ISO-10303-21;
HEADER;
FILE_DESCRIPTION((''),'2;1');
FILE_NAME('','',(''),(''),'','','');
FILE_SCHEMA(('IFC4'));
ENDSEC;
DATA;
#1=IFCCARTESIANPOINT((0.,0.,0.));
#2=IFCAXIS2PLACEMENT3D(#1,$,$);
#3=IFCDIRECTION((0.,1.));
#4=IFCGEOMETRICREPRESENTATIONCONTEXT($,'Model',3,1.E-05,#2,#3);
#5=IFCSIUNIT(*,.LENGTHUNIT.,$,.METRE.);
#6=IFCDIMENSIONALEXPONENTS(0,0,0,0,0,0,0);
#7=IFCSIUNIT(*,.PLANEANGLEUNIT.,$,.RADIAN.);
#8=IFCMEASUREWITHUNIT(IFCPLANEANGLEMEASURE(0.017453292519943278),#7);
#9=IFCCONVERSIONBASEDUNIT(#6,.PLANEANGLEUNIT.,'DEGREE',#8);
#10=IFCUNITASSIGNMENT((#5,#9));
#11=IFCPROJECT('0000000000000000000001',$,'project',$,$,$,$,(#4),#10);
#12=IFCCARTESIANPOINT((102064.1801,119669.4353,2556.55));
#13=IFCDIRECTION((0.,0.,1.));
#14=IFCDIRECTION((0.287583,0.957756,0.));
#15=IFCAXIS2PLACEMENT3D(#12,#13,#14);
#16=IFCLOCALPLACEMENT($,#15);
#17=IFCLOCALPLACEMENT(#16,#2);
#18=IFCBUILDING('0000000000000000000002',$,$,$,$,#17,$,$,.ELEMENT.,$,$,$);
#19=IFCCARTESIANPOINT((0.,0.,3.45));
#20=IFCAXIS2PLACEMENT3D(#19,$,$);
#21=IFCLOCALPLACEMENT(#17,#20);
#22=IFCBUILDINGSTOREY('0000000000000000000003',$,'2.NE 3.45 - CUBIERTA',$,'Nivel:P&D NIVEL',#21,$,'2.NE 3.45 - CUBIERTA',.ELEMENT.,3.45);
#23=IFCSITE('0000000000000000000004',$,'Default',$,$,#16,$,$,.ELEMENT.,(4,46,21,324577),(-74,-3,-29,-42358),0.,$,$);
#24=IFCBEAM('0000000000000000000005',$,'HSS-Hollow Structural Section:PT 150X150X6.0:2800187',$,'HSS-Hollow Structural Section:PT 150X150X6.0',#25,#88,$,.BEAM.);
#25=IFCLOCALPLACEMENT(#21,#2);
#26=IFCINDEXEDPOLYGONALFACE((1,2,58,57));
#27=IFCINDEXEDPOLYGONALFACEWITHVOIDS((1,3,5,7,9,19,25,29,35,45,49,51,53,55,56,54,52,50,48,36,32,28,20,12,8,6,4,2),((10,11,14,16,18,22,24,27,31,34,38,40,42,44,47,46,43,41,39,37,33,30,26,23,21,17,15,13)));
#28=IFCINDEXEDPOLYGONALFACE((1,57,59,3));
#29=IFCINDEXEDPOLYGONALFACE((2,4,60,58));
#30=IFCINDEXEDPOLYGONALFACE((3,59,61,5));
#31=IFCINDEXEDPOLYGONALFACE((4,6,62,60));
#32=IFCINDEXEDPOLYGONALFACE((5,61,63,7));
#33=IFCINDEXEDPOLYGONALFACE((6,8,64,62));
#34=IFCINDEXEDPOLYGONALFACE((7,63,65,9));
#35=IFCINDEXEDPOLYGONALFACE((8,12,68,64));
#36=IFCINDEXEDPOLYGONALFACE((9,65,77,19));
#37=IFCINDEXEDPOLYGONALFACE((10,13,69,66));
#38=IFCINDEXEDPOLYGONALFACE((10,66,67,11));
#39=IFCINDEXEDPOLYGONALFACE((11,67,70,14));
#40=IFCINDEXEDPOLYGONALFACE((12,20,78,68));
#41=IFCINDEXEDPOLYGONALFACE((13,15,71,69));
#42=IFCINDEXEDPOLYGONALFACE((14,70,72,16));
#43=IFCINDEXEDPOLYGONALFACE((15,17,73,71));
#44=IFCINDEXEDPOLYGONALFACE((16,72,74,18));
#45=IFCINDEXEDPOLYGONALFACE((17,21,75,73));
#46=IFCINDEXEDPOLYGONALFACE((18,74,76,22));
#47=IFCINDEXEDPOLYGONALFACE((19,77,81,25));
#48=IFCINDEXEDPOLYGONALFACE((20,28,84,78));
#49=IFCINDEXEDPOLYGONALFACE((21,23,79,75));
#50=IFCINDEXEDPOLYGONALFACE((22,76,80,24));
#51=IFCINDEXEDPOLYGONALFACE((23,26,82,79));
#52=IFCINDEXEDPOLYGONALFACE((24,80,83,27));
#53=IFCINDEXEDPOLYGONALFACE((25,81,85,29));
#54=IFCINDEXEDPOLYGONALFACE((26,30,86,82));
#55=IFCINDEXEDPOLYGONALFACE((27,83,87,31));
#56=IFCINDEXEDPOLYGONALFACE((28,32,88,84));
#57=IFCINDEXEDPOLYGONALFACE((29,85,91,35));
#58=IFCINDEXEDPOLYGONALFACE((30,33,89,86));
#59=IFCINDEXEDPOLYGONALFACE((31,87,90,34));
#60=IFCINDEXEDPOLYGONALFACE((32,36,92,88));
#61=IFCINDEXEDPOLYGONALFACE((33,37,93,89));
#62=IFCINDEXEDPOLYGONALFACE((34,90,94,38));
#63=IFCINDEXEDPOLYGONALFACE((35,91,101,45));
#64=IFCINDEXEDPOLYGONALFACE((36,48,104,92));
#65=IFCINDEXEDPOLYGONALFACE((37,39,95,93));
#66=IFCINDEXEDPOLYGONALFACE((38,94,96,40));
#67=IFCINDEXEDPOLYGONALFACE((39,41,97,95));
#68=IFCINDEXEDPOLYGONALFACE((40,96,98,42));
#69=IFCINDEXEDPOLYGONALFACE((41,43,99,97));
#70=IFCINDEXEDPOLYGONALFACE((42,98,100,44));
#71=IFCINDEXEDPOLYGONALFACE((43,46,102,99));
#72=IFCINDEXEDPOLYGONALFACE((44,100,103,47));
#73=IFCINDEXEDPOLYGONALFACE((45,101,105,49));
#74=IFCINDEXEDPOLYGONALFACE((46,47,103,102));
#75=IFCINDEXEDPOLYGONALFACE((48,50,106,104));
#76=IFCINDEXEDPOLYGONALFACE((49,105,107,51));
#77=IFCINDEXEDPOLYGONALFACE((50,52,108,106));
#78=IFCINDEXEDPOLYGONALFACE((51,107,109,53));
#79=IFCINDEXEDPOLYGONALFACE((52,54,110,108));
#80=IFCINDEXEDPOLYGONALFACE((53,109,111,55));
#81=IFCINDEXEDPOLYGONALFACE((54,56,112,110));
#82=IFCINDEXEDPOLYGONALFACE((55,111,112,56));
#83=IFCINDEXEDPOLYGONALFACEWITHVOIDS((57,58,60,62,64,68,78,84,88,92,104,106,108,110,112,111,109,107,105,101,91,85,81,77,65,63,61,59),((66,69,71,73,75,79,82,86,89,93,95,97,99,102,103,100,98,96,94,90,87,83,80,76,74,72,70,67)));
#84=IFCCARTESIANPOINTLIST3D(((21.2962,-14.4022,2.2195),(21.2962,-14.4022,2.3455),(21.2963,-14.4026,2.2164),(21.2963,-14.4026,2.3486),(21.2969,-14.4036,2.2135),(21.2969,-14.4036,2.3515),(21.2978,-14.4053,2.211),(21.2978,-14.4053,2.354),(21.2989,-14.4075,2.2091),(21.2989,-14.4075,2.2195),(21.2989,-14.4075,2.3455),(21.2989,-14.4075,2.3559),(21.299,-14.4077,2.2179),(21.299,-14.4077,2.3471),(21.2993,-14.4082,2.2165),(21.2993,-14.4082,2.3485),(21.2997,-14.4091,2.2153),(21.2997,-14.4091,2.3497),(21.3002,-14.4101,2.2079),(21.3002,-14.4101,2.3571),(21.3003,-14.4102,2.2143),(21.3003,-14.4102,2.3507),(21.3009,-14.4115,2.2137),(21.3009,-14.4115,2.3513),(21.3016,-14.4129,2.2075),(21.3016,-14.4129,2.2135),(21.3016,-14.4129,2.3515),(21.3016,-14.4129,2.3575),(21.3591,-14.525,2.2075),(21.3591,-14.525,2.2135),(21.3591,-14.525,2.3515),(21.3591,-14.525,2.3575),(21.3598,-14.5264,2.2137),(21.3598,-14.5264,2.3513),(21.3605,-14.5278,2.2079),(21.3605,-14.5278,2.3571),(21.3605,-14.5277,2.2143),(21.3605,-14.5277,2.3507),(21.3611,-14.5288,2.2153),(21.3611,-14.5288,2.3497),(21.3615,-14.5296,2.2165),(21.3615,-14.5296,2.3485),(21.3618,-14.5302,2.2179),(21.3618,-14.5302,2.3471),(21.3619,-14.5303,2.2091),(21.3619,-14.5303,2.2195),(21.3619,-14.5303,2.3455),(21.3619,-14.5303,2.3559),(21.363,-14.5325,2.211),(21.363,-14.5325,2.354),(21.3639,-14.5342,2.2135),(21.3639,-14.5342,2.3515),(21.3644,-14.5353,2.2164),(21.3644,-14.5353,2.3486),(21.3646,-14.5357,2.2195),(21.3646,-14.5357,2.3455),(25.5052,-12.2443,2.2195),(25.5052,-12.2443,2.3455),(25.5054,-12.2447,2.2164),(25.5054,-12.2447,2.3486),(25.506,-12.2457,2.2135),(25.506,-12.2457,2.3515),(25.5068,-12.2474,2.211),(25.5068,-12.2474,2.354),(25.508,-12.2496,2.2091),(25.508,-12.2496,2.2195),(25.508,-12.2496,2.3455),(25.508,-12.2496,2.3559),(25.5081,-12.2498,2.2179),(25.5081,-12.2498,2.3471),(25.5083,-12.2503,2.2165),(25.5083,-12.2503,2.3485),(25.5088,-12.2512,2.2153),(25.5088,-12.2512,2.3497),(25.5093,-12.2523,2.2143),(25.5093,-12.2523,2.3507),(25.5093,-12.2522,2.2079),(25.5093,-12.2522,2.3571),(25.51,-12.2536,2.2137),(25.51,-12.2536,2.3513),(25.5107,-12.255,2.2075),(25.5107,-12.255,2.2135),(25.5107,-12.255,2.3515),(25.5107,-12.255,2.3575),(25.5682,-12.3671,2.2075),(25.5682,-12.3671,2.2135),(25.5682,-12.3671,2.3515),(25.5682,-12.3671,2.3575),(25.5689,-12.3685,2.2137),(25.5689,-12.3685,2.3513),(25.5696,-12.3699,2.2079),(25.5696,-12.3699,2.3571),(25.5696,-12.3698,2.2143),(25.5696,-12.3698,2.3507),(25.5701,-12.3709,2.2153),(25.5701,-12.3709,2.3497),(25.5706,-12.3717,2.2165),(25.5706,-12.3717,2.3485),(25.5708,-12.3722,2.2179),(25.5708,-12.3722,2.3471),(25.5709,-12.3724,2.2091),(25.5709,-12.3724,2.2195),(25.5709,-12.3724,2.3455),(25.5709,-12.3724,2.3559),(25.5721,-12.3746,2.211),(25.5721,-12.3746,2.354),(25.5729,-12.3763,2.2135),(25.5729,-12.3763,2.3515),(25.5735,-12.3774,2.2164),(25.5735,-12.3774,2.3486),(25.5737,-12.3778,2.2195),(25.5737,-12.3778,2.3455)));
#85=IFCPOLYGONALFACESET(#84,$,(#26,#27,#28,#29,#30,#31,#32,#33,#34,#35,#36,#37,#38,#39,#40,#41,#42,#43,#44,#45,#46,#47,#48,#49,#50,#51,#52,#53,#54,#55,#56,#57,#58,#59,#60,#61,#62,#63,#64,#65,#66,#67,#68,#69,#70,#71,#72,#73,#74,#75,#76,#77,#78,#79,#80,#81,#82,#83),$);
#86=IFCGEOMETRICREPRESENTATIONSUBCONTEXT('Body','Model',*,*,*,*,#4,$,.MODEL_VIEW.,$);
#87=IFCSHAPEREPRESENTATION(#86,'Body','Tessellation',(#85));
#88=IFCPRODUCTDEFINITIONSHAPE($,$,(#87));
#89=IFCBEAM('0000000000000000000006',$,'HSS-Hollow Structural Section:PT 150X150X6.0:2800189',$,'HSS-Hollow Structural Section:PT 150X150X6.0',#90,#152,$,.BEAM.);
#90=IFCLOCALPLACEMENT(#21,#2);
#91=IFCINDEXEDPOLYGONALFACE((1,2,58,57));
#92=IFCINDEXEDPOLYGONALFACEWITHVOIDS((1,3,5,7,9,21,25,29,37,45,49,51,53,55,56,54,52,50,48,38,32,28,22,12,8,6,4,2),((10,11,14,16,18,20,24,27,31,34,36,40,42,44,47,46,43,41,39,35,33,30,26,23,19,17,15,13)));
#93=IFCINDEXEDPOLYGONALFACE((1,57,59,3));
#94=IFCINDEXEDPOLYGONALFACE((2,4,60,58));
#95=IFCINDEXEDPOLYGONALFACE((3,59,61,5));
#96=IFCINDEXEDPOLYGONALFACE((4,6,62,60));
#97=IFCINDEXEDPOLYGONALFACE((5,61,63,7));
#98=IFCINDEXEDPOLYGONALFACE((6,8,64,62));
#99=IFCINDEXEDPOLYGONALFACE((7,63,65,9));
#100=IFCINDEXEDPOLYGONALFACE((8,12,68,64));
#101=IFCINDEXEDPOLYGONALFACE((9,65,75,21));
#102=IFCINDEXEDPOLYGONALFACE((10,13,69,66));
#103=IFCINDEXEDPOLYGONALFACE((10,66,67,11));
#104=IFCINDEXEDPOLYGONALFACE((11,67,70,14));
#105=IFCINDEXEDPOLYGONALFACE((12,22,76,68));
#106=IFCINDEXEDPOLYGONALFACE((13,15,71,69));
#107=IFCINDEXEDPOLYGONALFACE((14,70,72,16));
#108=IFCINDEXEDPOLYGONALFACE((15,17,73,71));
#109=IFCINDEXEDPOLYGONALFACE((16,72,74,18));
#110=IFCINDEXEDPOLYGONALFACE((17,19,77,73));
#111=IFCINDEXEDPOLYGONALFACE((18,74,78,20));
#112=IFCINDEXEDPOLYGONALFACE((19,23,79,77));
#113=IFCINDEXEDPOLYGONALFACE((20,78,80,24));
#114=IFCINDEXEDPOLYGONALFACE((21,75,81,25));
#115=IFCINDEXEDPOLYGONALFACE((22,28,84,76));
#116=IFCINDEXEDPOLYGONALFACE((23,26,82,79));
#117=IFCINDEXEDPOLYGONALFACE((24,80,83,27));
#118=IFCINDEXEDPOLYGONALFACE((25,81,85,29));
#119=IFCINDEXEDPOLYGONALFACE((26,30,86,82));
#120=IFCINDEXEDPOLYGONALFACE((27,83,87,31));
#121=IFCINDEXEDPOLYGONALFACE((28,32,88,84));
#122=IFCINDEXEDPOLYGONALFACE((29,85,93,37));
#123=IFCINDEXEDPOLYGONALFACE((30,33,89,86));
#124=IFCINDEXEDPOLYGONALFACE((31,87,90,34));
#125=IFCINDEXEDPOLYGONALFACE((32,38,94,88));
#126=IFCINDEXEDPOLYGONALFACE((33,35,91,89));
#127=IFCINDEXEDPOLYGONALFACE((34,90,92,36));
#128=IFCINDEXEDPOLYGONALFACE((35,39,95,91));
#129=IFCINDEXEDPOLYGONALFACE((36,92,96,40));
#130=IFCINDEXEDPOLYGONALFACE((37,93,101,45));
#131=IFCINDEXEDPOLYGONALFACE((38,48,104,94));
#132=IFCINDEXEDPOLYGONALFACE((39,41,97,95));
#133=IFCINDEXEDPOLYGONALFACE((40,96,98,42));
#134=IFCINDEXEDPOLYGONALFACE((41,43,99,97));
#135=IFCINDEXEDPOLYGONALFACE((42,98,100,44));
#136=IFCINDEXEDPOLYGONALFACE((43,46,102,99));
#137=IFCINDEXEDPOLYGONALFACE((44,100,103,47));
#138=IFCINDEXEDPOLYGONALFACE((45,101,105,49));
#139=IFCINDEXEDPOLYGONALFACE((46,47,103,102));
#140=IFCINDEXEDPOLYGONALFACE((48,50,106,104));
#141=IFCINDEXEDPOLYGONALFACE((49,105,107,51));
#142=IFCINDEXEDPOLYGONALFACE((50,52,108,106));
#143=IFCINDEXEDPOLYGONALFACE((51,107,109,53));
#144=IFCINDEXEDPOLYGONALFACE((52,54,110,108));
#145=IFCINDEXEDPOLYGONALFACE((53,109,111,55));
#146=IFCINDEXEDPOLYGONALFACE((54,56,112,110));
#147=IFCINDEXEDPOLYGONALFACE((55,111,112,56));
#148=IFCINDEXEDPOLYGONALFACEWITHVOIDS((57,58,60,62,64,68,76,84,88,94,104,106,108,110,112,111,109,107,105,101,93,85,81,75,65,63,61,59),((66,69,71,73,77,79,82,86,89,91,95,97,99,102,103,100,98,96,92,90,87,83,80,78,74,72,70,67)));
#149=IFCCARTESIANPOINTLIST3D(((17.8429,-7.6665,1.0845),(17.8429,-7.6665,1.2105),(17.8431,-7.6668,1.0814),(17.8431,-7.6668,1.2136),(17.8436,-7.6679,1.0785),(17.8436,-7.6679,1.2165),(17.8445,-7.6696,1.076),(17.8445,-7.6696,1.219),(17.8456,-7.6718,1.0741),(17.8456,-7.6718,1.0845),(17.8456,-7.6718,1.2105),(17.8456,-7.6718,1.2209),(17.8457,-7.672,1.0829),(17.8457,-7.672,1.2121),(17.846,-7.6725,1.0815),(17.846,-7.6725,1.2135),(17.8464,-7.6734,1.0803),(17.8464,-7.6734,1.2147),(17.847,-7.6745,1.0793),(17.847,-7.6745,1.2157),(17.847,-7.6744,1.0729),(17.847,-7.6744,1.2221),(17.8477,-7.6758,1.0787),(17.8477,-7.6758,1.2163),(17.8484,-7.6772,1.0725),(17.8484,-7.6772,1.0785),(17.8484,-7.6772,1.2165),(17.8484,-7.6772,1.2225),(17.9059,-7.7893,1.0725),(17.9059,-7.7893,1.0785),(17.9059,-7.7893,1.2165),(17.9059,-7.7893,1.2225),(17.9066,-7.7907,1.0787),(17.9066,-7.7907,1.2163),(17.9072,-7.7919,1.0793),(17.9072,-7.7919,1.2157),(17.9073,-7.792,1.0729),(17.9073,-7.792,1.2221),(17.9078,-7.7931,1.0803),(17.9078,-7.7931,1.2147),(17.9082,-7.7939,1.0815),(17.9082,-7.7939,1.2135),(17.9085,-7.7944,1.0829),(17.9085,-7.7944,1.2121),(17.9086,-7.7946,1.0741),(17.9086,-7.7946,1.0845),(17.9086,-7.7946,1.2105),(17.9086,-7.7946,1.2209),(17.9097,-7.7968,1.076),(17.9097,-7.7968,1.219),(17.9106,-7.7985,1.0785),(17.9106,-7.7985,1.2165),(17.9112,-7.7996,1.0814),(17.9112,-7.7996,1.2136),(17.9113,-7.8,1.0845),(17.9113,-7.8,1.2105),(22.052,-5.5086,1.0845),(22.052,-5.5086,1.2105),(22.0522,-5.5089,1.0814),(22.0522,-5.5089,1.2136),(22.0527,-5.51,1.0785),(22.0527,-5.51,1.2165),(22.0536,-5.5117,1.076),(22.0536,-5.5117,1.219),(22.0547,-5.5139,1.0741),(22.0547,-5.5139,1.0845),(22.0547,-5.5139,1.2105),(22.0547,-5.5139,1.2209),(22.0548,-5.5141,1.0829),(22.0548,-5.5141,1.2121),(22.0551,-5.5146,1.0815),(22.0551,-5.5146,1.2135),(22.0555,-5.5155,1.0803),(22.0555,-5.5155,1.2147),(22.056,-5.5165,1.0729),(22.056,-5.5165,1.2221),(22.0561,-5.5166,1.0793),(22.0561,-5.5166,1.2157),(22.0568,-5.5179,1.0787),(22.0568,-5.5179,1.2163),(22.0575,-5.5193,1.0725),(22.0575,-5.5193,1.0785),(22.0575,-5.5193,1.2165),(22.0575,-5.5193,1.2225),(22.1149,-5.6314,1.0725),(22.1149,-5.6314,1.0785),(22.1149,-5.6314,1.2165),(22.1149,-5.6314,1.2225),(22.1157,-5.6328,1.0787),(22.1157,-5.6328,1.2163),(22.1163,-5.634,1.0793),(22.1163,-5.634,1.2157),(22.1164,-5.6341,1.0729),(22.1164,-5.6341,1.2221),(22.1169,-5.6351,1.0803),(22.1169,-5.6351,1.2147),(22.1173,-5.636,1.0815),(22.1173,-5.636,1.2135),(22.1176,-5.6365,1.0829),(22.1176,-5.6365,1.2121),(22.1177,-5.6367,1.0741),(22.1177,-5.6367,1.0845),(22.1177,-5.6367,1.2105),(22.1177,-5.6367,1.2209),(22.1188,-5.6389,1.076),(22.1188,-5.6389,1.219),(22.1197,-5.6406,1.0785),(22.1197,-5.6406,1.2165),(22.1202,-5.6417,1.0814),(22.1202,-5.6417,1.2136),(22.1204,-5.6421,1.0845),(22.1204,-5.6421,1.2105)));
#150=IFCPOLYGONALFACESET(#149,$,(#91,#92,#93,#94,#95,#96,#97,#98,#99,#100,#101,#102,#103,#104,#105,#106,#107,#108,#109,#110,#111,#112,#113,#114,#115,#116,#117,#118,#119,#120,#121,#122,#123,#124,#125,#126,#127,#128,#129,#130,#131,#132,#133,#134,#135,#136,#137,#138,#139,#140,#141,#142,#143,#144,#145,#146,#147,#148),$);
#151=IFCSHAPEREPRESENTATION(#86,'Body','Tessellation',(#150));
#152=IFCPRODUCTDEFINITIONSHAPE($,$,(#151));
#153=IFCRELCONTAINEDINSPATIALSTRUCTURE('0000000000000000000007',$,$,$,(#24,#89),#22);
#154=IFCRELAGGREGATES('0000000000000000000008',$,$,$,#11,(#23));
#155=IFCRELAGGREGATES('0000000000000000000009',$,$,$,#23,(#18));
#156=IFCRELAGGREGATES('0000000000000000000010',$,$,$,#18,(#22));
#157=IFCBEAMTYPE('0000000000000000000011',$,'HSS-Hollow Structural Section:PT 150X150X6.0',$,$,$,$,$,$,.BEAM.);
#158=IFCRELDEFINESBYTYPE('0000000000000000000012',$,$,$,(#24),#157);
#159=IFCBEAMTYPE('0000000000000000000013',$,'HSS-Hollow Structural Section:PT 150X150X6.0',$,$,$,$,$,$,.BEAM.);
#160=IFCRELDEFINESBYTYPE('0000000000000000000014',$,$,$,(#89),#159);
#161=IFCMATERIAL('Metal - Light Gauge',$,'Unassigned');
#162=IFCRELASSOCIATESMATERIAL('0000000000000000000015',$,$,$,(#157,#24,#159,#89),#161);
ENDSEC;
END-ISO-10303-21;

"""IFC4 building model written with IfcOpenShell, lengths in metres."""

from ifc_helpers import new_model, entity, si_unit, converted_unit, direction, frame, origin, place, context, subcontext, project, spatial, line, arc, indexed_curve, outline, extrude, source, transform, mapped, material, type_object, type_shapes, element, save


model = new_model("IFC4")

# Units and contexts
model_context = context("Model", 3, precision=1e-05, world=origin(), true_north=direction((0.0, 1.0)))
body_context = subcontext(model_context, "Body", "Model", "MODEL_VIEW")
ifc_project = project(units=[si_unit("LENGTHUNIT", "METRE"), converted_unit("PLANEANGLEUNIT", "DEGREE", entity("IfcPlaneAngleMeasure", 0.017453292519943278), si_unit("PLANEANGLEUNIT", "RADIAN"), dimensions=[0, 0, 0, 0, 0, 0, 0])], contexts=[model_context])

# Site, building, storey
site_placement = place(None, frame((102064.1801, 119669.4353, 2556.55), z_axis=(0.0, 0.0, 1.0), x_axis=(0.287583, 0.957756, 0.0)))
site = spatial("IfcSite", under=ifc_project, at=site_placement, Name="Default", CompositionType="ELEMENT", RefLatitude=(4, 46, 21, 324577), RefLongitude=(-74, -3, -29, -42358), RefElevation=0.0)
building_placement = place(site_placement, origin())
building = spatial("IfcBuilding", under=site, at=building_placement, CompositionType="ELEMENT")
storey_placement = place(building_placement, frame((0.0, 0.0, 3.45)))
storey = spatial("IfcBuildingStorey", under=building, at=storey_placement, Name="2.NE 3.45 - CUBIERTA", ObjectType="Nivel:P&D NIVEL", LongName="2.NE 3.45 - CUBIERTA", CompositionType="ELEMENT", Elevation=3.45)

# Beams
ifc_material_1 = material(Name="Metal - Light Gauge", Category="Unassigned")
beam_type_1 = type_object("IfcBeamType", Name="HSS-Hollow Structural Section:PT 150X150X6.0", PredefinedType="BEAM", material=ifc_material_1)
shared_shape_1 = source(origin(), body_context, "Body", "SweptSolid", [
    extrude(outline(indexed_curve([(-0.063, -0.075), (0.063, -0.075), (0.0715, -0.0715), (0.075, -0.063), (0.075, 0.063), (0.0715, 0.0715), (0.063, 0.075), (-0.063, 0.075), (-0.0715, 0.0715), (-0.075, 0.063), (-0.075, -0.063), (-0.0715, -0.0715)], segments=[line(1, 2), arc(2, 3, 4), line(4, 5), arc(5, 6, 7), line(7, 8), arc(8, 9, 10), line(10, 11), arc(11, 12, 1)], self_intersect=False), holes=[indexed_curve([(-0.069, 0.063), (-0.0672, 0.0672), (-0.063, 0.069), (0.063, 0.069), (0.0672, 0.0672), (0.069, 0.063), (0.069, -0.063), (0.0672, -0.0672), (0.063, -0.069), (-0.063, -0.069), (-0.0672, -0.0672), (-0.069, -0.063)], segments=[arc(1, 2, 3), line(3, 4), arc(4, 5, 6), line(6, 7), arc(7, 8, 9), line(9, 10), arc(10, 11, 12), line(12, 1)], self_intersect=False)]), frame((21.3304, -14.4689, 5.7325), z_axis=(0.889869, 0.456217, 0.0), x_axis=(0.0, 0.0, -1.0)), (0.0, 0.0, 1.0), 4.73),
])
type_shapes(beam_type_1, [shared_shape_1])
beam_1_placement = place(storey_placement, frame((0.0, 0.0, -3.45)))
element("IfcBeam", 1, at=beam_1_placement, inside=storey, type_object=beam_type_1, material=ifc_material_1, Name="HSS-Hollow Structural Section:PT 150X150X6.0:2800187", ObjectType="HSS-Hollow Structural Section:PT 150X150X6.0", PredefinedType="BEAM", context=body_context, shape_type="MappedRepresentation", body=[
    mapped(shared_shape_1, transform((0.0, 0.0, 0.0), scale=1.0)),
])
beam_type_2 = type_object("IfcBeamType", Name="HSS-Hollow Structural Section:PT 150X150X6.0", PredefinedType="BEAM", material=ifc_material_1)
shared_shape_2 = source(origin(), body_context, "Body", "SweptSolid", [
    extrude(outline(indexed_curve([(-0.063, -0.075), (0.063, -0.075), (0.0715, -0.0715), (0.075, -0.063), (0.075, 0.063), (0.0715, 0.0715), (0.063, 0.075), (-0.063, 0.075), (-0.0715, 0.0715), (-0.075, 0.063), (-0.075, -0.063), (-0.0715, -0.0715)], segments=[line(1, 2), arc(2, 3, 4), line(4, 5), arc(5, 6, 7), line(7, 8), arc(8, 9, 10), line(10, 11), arc(11, 12, 1)], self_intersect=False), holes=[indexed_curve([(-0.069, 0.063), (-0.0672, 0.0672), (-0.063, 0.069), (0.063, 0.069), (0.0672, 0.0672), (0.069, 0.063), (0.069, -0.063), (0.0672, -0.0672), (0.063, -0.069), (-0.063, -0.069), (-0.0672, -0.0672), (-0.069, -0.063)], segments=[arc(1, 2, 3), line(3, 4), arc(4, 5, 6), line(6, 7), arc(7, 8, 9), line(9, 10), arc(10, 11, 12), line(12, 1)], self_intersect=False)]), frame((17.8771, -7.7332, 4.5975), z_axis=(0.889869, 0.456217, 0.0), x_axis=(0.0, 0.0, -1.0)), (0.0, 0.0, 1.0), 4.73),
])
type_shapes(beam_type_2, [shared_shape_2])
beam_2_placement = place(storey_placement, frame((0.0, 0.0, -3.45)))
element("IfcBeam", 2, at=beam_2_placement, inside=storey, type_object=beam_type_2, material=ifc_material_1, Name="HSS-Hollow Structural Section:PT 150X150X6.0:2800189", ObjectType="HSS-Hollow Structural Section:PT 150X150X6.0", PredefinedType="BEAM", context=body_context, shape_type="MappedRepresentation", body=[
    mapped(shared_shape_2, transform((0.0, 0.0, 0.0), scale=1.0)),
])

save(model, "model.ifc")
